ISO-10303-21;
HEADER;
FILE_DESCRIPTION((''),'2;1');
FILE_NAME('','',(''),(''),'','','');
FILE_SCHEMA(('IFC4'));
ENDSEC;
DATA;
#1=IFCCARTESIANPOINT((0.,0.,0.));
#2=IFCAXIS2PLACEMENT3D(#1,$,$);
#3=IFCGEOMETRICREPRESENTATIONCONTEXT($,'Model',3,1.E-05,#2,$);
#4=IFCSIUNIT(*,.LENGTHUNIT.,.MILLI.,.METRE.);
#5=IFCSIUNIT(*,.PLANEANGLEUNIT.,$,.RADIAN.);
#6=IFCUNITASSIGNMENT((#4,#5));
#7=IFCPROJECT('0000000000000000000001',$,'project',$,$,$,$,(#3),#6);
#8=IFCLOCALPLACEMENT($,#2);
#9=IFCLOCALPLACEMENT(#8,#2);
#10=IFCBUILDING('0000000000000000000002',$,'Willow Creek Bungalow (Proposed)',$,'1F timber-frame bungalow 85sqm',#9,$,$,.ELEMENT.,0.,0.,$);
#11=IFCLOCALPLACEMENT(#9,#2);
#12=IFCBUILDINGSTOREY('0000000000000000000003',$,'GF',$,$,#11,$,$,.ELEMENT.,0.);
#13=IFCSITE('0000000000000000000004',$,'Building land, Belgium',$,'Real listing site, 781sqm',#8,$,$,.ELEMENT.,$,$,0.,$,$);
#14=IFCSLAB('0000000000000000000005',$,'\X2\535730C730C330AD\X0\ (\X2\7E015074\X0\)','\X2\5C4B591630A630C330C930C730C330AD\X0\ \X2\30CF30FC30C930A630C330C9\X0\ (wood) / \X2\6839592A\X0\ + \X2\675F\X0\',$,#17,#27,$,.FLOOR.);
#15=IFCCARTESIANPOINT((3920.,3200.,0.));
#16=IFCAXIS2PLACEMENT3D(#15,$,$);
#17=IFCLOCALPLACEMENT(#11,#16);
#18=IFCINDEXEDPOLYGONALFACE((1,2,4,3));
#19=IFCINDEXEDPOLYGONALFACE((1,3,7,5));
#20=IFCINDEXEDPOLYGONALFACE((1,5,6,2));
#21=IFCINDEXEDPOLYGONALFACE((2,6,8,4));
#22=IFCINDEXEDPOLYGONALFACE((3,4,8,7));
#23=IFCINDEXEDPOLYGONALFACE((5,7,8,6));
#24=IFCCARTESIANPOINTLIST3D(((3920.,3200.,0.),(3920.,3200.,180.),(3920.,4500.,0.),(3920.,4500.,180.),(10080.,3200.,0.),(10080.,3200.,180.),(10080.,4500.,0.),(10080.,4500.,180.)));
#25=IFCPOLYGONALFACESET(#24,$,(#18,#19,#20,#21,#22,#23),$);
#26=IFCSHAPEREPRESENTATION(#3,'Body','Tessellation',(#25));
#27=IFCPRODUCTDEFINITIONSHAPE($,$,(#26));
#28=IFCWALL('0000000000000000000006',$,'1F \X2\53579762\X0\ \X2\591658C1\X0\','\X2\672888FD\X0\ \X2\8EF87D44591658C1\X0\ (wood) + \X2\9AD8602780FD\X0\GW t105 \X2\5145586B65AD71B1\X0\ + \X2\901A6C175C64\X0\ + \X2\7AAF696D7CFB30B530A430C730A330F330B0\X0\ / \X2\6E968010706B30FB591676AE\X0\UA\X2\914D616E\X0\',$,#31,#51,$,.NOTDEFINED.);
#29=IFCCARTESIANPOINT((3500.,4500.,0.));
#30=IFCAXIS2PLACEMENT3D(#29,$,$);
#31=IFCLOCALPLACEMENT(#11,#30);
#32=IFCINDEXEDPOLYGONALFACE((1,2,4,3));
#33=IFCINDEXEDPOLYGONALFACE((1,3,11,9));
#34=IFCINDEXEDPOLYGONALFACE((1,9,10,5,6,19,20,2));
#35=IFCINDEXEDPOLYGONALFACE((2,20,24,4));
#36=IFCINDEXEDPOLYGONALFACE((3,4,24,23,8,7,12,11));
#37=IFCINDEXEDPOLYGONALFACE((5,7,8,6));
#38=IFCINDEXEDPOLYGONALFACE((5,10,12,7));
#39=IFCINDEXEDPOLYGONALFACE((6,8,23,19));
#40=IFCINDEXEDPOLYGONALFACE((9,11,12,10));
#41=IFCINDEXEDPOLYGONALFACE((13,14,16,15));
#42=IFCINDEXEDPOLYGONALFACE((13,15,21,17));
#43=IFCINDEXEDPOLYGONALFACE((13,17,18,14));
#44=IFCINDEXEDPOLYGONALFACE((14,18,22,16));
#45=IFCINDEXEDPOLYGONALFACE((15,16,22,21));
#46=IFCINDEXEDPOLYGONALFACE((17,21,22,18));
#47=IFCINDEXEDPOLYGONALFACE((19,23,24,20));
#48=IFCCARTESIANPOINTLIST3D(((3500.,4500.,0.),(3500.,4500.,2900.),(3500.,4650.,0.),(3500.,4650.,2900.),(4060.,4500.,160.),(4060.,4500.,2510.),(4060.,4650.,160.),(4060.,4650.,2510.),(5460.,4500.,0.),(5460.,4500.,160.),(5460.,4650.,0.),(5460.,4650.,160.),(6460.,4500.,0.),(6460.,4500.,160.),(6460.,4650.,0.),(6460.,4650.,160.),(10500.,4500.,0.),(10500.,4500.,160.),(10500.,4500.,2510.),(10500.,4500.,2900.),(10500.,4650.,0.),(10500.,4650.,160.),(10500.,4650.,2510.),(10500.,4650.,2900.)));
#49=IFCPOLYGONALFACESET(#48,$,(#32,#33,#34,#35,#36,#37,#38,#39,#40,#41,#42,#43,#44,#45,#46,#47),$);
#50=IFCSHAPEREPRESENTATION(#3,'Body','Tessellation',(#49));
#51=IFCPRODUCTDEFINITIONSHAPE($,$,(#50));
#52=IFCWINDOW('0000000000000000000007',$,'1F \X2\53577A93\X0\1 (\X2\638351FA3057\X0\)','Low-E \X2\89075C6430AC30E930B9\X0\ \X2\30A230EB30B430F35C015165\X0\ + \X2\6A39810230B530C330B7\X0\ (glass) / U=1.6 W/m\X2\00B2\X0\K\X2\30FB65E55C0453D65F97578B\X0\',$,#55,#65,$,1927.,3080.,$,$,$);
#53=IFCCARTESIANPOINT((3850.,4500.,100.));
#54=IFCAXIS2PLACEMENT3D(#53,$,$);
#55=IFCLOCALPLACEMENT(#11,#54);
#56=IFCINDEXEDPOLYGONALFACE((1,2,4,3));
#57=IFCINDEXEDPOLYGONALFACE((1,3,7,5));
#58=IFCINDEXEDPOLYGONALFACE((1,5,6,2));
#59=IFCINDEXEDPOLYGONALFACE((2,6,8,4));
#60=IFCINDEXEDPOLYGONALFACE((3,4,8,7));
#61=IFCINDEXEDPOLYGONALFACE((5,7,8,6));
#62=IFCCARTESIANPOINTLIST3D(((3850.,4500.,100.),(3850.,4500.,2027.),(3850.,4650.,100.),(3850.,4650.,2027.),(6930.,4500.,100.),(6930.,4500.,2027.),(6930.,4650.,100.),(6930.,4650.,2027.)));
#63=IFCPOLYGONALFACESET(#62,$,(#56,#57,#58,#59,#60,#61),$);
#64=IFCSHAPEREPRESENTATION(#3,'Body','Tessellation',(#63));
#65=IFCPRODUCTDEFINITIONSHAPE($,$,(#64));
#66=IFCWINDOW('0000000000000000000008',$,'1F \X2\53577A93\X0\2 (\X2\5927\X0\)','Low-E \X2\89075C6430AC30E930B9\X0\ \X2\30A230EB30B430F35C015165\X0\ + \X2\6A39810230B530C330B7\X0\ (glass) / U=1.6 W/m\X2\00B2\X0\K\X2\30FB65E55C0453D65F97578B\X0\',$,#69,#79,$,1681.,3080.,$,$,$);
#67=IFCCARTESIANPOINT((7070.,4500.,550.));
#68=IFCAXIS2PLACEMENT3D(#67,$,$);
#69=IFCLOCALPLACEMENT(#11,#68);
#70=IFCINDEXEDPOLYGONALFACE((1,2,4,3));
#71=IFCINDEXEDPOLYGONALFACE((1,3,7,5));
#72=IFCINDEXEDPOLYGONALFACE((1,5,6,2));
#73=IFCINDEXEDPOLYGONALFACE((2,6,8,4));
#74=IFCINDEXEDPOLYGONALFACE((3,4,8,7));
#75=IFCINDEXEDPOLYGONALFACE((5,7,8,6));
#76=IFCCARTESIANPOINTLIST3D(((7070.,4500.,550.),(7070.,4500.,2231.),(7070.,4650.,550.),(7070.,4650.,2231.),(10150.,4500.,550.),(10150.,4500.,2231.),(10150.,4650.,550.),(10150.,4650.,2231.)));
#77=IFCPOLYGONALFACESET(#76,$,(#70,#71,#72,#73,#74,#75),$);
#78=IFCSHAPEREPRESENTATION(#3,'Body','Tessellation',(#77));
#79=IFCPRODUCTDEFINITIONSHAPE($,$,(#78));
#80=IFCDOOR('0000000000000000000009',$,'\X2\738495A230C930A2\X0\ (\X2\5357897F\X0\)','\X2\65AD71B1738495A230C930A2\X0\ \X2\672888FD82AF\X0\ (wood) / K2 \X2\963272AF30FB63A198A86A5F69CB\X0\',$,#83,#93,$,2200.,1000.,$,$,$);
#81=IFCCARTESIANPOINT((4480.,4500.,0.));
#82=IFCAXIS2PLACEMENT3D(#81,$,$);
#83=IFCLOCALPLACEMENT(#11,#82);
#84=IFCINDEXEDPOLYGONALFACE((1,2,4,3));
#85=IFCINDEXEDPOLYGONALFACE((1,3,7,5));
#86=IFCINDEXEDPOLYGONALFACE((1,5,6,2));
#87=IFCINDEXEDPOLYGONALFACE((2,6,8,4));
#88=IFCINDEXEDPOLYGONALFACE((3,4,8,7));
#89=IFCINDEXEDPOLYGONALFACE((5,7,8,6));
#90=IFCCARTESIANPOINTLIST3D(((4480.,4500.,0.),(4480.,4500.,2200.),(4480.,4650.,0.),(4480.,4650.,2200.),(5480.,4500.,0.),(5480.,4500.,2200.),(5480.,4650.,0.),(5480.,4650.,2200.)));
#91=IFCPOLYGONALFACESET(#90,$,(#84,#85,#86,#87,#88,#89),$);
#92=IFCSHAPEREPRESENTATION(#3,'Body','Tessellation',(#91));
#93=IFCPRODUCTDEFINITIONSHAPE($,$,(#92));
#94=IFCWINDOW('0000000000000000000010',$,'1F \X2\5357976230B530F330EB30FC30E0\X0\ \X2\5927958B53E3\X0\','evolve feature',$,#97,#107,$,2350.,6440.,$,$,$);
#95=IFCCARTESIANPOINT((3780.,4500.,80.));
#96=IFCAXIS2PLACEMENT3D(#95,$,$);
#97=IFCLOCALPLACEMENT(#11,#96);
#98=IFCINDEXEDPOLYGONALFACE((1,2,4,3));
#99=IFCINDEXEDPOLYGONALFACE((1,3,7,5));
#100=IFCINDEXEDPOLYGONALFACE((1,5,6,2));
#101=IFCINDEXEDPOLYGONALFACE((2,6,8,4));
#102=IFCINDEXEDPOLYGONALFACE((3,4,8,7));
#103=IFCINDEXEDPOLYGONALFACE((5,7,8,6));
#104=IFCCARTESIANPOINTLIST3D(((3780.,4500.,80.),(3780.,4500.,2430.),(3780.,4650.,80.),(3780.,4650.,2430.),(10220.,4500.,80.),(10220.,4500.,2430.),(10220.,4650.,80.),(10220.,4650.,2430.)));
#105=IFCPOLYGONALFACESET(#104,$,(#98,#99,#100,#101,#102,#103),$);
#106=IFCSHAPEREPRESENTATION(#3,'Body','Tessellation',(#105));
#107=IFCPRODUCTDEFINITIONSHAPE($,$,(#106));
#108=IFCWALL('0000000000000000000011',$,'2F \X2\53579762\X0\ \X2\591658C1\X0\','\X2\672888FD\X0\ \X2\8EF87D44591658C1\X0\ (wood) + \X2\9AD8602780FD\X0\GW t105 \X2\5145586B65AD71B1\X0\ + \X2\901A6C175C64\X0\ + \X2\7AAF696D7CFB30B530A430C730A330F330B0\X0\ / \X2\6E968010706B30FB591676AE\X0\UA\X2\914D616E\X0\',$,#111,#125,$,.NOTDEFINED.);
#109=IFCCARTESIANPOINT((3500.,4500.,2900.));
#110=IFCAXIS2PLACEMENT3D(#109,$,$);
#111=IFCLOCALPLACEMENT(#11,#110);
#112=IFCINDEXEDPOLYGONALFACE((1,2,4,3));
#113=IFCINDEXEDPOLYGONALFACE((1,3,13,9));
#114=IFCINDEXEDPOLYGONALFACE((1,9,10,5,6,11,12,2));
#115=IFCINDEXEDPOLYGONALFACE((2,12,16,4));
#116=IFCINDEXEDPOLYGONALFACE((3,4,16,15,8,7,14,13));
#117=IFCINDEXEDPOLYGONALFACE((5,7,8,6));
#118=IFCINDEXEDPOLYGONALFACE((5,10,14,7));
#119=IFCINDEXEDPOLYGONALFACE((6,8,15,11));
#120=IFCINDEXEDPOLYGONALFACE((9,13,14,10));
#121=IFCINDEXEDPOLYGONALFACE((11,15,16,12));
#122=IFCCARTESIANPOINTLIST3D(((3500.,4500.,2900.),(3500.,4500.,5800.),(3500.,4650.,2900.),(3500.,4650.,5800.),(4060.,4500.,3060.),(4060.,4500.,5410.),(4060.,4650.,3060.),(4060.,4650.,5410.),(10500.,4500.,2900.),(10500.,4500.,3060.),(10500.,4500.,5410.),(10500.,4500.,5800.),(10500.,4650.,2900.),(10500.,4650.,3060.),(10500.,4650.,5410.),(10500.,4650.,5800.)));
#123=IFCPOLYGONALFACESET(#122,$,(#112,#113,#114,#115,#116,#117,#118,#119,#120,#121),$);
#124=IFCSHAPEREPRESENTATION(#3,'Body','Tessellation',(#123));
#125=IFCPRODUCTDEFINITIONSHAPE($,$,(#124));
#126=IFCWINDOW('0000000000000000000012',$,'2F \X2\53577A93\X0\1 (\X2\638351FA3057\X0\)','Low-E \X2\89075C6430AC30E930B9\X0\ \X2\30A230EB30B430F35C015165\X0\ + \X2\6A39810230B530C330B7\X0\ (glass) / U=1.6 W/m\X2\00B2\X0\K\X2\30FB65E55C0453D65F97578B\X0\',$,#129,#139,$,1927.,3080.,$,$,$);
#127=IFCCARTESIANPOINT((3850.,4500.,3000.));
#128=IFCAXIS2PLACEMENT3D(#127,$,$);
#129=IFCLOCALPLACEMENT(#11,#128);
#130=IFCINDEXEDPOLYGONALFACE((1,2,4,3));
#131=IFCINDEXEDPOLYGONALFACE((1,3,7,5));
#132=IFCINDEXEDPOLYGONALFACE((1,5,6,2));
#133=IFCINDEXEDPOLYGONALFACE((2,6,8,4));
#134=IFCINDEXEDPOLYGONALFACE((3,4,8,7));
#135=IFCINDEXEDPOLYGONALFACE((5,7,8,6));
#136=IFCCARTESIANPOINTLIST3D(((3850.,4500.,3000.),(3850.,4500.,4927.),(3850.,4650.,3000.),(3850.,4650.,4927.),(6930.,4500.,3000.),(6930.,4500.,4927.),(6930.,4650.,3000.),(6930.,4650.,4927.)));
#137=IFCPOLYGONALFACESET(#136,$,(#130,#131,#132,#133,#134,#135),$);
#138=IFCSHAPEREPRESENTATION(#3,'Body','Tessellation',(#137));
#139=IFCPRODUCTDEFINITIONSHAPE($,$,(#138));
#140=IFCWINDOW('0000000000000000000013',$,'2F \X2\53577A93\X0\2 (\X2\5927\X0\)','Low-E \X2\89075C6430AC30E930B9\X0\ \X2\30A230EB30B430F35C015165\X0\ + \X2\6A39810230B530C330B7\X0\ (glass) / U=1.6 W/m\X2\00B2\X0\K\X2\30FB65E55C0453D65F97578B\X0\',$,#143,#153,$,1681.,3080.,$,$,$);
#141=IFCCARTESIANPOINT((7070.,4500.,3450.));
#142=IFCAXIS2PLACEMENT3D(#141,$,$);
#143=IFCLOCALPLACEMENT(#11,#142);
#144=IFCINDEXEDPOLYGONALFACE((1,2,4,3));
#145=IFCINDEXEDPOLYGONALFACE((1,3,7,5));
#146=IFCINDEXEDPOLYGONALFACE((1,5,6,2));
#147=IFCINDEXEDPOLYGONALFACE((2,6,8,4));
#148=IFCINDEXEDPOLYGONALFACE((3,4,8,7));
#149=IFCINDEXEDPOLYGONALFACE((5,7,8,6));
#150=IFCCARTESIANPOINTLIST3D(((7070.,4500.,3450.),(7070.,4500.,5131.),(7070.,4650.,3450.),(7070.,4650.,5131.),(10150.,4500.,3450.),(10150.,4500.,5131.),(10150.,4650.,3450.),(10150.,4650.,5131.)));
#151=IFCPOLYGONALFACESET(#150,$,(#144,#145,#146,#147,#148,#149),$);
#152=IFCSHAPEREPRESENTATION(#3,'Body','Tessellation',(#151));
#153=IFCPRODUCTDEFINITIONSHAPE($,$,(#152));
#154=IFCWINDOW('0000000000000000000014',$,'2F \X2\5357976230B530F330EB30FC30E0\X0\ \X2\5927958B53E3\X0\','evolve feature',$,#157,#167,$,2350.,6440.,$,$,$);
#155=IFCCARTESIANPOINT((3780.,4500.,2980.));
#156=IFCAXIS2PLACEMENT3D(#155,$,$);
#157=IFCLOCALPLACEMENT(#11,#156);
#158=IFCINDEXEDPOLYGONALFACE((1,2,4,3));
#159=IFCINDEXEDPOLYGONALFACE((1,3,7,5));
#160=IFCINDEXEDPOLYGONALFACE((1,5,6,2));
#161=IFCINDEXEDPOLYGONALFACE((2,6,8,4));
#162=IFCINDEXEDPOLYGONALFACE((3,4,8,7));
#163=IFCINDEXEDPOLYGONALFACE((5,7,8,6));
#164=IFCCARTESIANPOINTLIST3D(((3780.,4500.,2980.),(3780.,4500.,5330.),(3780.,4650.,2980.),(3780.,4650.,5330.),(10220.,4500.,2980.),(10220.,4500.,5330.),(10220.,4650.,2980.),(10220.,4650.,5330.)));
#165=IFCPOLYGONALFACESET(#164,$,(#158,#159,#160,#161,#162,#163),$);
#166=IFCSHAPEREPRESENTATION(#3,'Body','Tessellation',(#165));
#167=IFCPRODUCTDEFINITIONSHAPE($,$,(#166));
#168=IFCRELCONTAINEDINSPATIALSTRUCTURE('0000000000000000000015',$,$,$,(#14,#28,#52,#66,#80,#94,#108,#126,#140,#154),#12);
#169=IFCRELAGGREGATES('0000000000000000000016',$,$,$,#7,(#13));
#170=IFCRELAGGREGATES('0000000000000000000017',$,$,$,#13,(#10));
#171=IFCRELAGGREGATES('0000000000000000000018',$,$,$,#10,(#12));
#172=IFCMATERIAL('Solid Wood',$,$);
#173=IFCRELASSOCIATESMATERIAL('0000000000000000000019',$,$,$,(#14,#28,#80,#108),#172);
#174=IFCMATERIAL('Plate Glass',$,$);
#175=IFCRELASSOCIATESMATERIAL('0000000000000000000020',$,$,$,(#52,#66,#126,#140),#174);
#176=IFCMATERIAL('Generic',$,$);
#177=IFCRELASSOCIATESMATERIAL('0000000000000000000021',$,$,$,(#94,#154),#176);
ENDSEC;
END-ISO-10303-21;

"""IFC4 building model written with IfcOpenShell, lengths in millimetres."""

from ifc_helpers import new_model, si_unit, frame, frame_2d, origin, place, context, project, spatial, rectangle, extrude, material, element, fill, save


model = new_model("IFC4")

# Units and contexts
model_context = context("Model", 3, precision=1e-05, world=origin())
ifc_project = project(units=[si_unit("LENGTHUNIT", "METRE", prefix="MILLI"), si_unit("PLANEANGLEUNIT", "RADIAN")], contexts=[model_context])

# Site, building, storey
site_placement = place(None, origin())
site = spatial("IfcSite", under=ifc_project, at=site_placement, Name="Building land, Belgium", ObjectType="Real listing site, 781sqm", CompositionType="ELEMENT", RefElevation=0.0)
building_placement = place(site_placement, origin())
building = spatial("IfcBuilding", under=site, at=building_placement, Name="Willow Creek Bungalow (Proposed)", ObjectType="1F timber-frame bungalow 85sqm", CompositionType="ELEMENT", ElevationOfRefHeight=0.0, ElevationOfTerrain=0.0)
storey_placement = place(building_placement, origin())
storey = spatial("IfcBuildingStorey", under=building, at=storey_placement, Name="GF", CompositionType="ELEMENT", Elevation=0.0)

# Slab
ifc_material_1 = material(Name="Solid Wood")
slab_1_placement = place(storey_placement, frame((3920.0, 3200.0, 0.0)))
element("IfcSlab", 1, at=slab_1_placement, inside=storey, material=ifc_material_1, Name="南デッキ (縁側)", Description="屋外ウッドデッキ ハードウッド (wood) / 根太 + 束", PredefinedType="FLOOR", context=model_context, shape_type="SweptSolid", body=[
    extrude(rectangle(XDim=6160.0, YDim=1300.0, at=frame_2d((3080.0, 650.0))), frame((3920.0, 3200.0, 0.0)), (0.0, 0.0, 1.0), 180.0),
])
ifc_material_2 = material(Name="Generic")

# Wall, openings, windows, door
wall_1_placement = place(storey_placement, frame((3500.0, 4500.0, 0.0)))
wall_1 = element("IfcWall", 2, at=wall_1_placement, inside=storey, material=ifc_material_1, Name="1F 南面 外壁", Description="木製 軸組外壁 (wood) + 高性能GW t105 充填断熱 + 通気層 + 窯業系サイディング / 準耐火・外皮UA配慮", PredefinedType="NOTDEFINED", context=model_context, shape_type="SweptSolid", body=[
    extrude(rectangle(XDim=7000.0, YDim=150.0, at=frame_2d((3500.0, 75.0))), frame((3500.0, 4500.0, 0.0)), (0.0, 0.0, 1.0), 2900.0),
])
opening_1_placement = place(storey_placement, frame((3850.0, 4500.0, 100.0)))
opening_1 = element("IfcOpeningElement", 3, at=opening_1_placement, cuts=wall_1, PredefinedType="NOTDEFINED", context=model_context, shape_type="SweptSolid", body=[
    extrude(rectangle(XDim=3080.0, YDim=150.0, at=frame_2d((1540.0, 75.0))), frame((3850.0, 4500.0, 100.0)), (0.0, 0.0, 1.0), 1927.0),
])
opening_2_placement = place(storey_placement, frame((7070.0, 4500.0, 550.0)))
opening_2 = element("IfcOpeningElement", 4, at=opening_2_placement, cuts=wall_1, PredefinedType="NOTDEFINED", context=model_context, shape_type="SweptSolid", body=[
    extrude(rectangle(XDim=3080.0, YDim=150.0, at=frame_2d((1540.0, 75.0))), frame((7070.0, 4500.0, 550.0)), (0.0, 0.0, 1.0), 1681.0),
])
opening_3_placement = place(storey_placement, frame((4480.0, 4500.0, 0.0)))
opening_3 = element("IfcOpeningElement", 5, at=opening_3_placement, cuts=wall_1, PredefinedType="NOTDEFINED", context=model_context, shape_type="SweptSolid", body=[
    extrude(rectangle(XDim=1000.0, YDim=150.0, at=frame_2d((500.0, 75.0))), frame((4480.0, 4500.0, 0.0)), (0.0, 0.0, 1.0), 2200.0),
])
opening_4_placement = place(storey_placement, frame((3780.0, 4500.0, 80.0)))
opening_4 = element("IfcOpeningElement", 6, at=opening_4_placement, cuts=wall_1, PredefinedType="NOTDEFINED", context=model_context, shape_type="SweptSolid", body=[
    extrude(rectangle(XDim=6440.0, YDim=150.0, at=frame_2d((3220.0, 75.0))), frame((3780.0, 4500.0, 80.0)), (0.0, 0.0, 1.0), 2350.0),
])
ifc_material_3 = material(Name="Plate Glass")
window_1_placement = place(storey_placement, frame((3850.0, 4500.0, 100.0)))
window_1 = element("IfcWindow", 7, at=window_1_placement, inside=storey, material=ifc_material_3, Name="1F 南窓1 (掃出し)", Description="Low-E 複層ガラス アルゴン封入 + 樹脂サッシ (glass) / U=1.6 W/m²K・日射取得型", OverallHeight=1927.0, OverallWidth=3080.0, context=model_context, shape_type="SweptSolid", body=[
    extrude(rectangle(XDim=3080.0, YDim=150.0, at=frame_2d((1540.0, 75.0))), frame((3850.0, 4500.0, 100.0)), (0.0, 0.0, 1.0), 1927.0),
])
fill(opening_1, window_1)
window_2_placement = place(storey_placement, frame((7070.0, 4500.0, 550.0)))
window_2 = element("IfcWindow", 8, at=window_2_placement, inside=storey, material=ifc_material_3, Name="1F 南窓2 (大)", Description="Low-E 複層ガラス アルゴン封入 + 樹脂サッシ (glass) / U=1.6 W/m²K・日射取得型", OverallHeight=1681.0, OverallWidth=3080.0, context=model_context, shape_type="SweptSolid", body=[
    extrude(rectangle(XDim=3080.0, YDim=150.0, at=frame_2d((1540.0, 75.0))), frame((7070.0, 4500.0, 550.0)), (0.0, 0.0, 1.0), 1681.0),
])
fill(opening_2, window_2)
door_placement = place(storey_placement, frame((4480.0, 4500.0, 0.0)))
door = element("IfcDoor", 9, at=door_placement, inside=storey, material=ifc_material_1, Name="玄関ドア (南西)", Description="断熱玄関ドア 木製芯 (wood) / K2 防犯・採風機構", OverallHeight=2200.0, OverallWidth=1000.0, context=model_context, shape_type="SweptSolid", body=[
    extrude(rectangle(XDim=1000.0, YDim=150.0, at=frame_2d((500.0, 75.0))), frame((4480.0, 4500.0, 0.0)), (0.0, 0.0, 1.0), 2200.0),
])
fill(opening_3, door)
window_3_placement = place(storey_placement, frame((3780.0, 4500.0, 80.0)))
window_3 = element("IfcWindow", 10, at=window_3_placement, inside=storey, material=ifc_material_2, Name="1F 南面サンルーム 大開口", Description="evolve feature", OverallHeight=2350.0, OverallWidth=6440.0, context=model_context, shape_type="SweptSolid", body=[
    extrude(rectangle(XDim=6440.0, YDim=150.0, at=frame_2d((3220.0, 75.0))), frame((3780.0, 4500.0, 80.0)), (0.0, 0.0, 1.0), 2350.0),
])
fill(opening_4, window_3)

# Wall, openings, windows
wall_2_placement = place(storey_placement, frame((3500.0, 4500.0, 2900.0)))
wall_2 = element("IfcWall", 11, at=wall_2_placement, inside=storey, material=ifc_material_1, Name="2F 南面 外壁", Description="木製 軸組外壁 (wood) + 高性能GW t105 充填断熱 + 通気層 + 窯業系サイディング / 準耐火・外皮UA配慮", PredefinedType="NOTDEFINED", context=model_context, shape_type="SweptSolid", body=[
    extrude(rectangle(XDim=7000.0, YDim=150.0, at=frame_2d((3500.0, 75.0))), frame((3500.0, 4500.0, 2900.0)), (0.0, 0.0, 1.0), 2900.0),
])
opening_5_placement = place(storey_placement, frame((3850.0, 4500.0, 3000.0)))
opening_5 = element("IfcOpeningElement", 12, at=opening_5_placement, cuts=wall_2, PredefinedType="NOTDEFINED", context=model_context, shape_type="SweptSolid", body=[
    extrude(rectangle(XDim=3080.0, YDim=150.0, at=frame_2d((1540.0, 75.0))), frame((3850.0, 4500.0, 3000.0)), (0.0, 0.0, 1.0), 1927.0),
])
opening_6_placement = place(storey_placement, frame((7070.0, 4500.0, 3450.0)))
opening_6 = element("IfcOpeningElement", 13, at=opening_6_placement, cuts=wall_2, PredefinedType="NOTDEFINED", context=model_context, shape_type="SweptSolid", body=[
    extrude(rectangle(XDim=3080.0, YDim=150.0, at=frame_2d((1540.0, 75.0))), frame((7070.0, 4500.0, 3450.0)), (0.0, 0.0, 1.0), 1681.0),
])
opening_7_placement = place(storey_placement, frame((3780.0, 4500.0, 2980.0)))
opening_7 = element("IfcOpeningElement", 14, at=opening_7_placement, cuts=wall_2, PredefinedType="NOTDEFINED", context=model_context, shape_type="SweptSolid", body=[
    extrude(rectangle(XDim=6440.0, YDim=150.0, at=frame_2d((3220.0, 75.0))), frame((3780.0, 4500.0, 2980.0)), (0.0, 0.0, 1.0), 2350.0),
])
window_4_placement = place(storey_placement, frame((3850.0, 4500.0, 3000.0)))
window_4 = element("IfcWindow", 15, at=window_4_placement, inside=storey, material=ifc_material_3, Name="2F 南窓1 (掃出し)", Description="Low-E 複層ガラス アルゴン封入 + 樹脂サッシ (glass) / U=1.6 W/m²K・日射取得型", OverallHeight=1927.0, OverallWidth=3080.0, context=model_context, shape_type="SweptSolid", body=[
    extrude(rectangle(XDim=3080.0, YDim=150.0, at=frame_2d((1540.0, 75.0))), frame((3850.0, 4500.0, 3000.0)), (0.0, 0.0, 1.0), 1927.0),
])
fill(opening_5, window_4)
window_5_placement = place(storey_placement, frame((7070.0, 4500.0, 3450.0)))
window_5 = element("IfcWindow", 16, at=window_5_placement, inside=storey, material=ifc_material_3, Name="2F 南窓2 (大)", Description="Low-E 複層ガラス アルゴン封入 + 樹脂サッシ (glass) / U=1.6 W/m²K・日射取得型", OverallHeight=1681.0, OverallWidth=3080.0, context=model_context, shape_type="SweptSolid", body=[
    extrude(rectangle(XDim=3080.0, YDim=150.0, at=frame_2d((1540.0, 75.0))), frame((7070.0, 4500.0, 3450.0)), (0.0, 0.0, 1.0), 1681.0),
])
fill(opening_6, window_5)
window_6_placement = place(storey_placement, frame((3780.0, 4500.0, 2980.0)))
window_6 = element("IfcWindow", 17, at=window_6_placement, inside=storey, material=ifc_material_2, Name="2F 南面サンルーム 大開口", Description="evolve feature", OverallHeight=2350.0, OverallWidth=6440.0, context=model_context, shape_type="SweptSolid", body=[
    extrude(rectangle(XDim=6440.0, YDim=150.0, at=frame_2d((3220.0, 75.0))), frame((3780.0, 4500.0, 2980.0)), (0.0, 0.0, 1.0), 2350.0),
])
fill(opening_7, window_6)

save(model, "model.ifc")
